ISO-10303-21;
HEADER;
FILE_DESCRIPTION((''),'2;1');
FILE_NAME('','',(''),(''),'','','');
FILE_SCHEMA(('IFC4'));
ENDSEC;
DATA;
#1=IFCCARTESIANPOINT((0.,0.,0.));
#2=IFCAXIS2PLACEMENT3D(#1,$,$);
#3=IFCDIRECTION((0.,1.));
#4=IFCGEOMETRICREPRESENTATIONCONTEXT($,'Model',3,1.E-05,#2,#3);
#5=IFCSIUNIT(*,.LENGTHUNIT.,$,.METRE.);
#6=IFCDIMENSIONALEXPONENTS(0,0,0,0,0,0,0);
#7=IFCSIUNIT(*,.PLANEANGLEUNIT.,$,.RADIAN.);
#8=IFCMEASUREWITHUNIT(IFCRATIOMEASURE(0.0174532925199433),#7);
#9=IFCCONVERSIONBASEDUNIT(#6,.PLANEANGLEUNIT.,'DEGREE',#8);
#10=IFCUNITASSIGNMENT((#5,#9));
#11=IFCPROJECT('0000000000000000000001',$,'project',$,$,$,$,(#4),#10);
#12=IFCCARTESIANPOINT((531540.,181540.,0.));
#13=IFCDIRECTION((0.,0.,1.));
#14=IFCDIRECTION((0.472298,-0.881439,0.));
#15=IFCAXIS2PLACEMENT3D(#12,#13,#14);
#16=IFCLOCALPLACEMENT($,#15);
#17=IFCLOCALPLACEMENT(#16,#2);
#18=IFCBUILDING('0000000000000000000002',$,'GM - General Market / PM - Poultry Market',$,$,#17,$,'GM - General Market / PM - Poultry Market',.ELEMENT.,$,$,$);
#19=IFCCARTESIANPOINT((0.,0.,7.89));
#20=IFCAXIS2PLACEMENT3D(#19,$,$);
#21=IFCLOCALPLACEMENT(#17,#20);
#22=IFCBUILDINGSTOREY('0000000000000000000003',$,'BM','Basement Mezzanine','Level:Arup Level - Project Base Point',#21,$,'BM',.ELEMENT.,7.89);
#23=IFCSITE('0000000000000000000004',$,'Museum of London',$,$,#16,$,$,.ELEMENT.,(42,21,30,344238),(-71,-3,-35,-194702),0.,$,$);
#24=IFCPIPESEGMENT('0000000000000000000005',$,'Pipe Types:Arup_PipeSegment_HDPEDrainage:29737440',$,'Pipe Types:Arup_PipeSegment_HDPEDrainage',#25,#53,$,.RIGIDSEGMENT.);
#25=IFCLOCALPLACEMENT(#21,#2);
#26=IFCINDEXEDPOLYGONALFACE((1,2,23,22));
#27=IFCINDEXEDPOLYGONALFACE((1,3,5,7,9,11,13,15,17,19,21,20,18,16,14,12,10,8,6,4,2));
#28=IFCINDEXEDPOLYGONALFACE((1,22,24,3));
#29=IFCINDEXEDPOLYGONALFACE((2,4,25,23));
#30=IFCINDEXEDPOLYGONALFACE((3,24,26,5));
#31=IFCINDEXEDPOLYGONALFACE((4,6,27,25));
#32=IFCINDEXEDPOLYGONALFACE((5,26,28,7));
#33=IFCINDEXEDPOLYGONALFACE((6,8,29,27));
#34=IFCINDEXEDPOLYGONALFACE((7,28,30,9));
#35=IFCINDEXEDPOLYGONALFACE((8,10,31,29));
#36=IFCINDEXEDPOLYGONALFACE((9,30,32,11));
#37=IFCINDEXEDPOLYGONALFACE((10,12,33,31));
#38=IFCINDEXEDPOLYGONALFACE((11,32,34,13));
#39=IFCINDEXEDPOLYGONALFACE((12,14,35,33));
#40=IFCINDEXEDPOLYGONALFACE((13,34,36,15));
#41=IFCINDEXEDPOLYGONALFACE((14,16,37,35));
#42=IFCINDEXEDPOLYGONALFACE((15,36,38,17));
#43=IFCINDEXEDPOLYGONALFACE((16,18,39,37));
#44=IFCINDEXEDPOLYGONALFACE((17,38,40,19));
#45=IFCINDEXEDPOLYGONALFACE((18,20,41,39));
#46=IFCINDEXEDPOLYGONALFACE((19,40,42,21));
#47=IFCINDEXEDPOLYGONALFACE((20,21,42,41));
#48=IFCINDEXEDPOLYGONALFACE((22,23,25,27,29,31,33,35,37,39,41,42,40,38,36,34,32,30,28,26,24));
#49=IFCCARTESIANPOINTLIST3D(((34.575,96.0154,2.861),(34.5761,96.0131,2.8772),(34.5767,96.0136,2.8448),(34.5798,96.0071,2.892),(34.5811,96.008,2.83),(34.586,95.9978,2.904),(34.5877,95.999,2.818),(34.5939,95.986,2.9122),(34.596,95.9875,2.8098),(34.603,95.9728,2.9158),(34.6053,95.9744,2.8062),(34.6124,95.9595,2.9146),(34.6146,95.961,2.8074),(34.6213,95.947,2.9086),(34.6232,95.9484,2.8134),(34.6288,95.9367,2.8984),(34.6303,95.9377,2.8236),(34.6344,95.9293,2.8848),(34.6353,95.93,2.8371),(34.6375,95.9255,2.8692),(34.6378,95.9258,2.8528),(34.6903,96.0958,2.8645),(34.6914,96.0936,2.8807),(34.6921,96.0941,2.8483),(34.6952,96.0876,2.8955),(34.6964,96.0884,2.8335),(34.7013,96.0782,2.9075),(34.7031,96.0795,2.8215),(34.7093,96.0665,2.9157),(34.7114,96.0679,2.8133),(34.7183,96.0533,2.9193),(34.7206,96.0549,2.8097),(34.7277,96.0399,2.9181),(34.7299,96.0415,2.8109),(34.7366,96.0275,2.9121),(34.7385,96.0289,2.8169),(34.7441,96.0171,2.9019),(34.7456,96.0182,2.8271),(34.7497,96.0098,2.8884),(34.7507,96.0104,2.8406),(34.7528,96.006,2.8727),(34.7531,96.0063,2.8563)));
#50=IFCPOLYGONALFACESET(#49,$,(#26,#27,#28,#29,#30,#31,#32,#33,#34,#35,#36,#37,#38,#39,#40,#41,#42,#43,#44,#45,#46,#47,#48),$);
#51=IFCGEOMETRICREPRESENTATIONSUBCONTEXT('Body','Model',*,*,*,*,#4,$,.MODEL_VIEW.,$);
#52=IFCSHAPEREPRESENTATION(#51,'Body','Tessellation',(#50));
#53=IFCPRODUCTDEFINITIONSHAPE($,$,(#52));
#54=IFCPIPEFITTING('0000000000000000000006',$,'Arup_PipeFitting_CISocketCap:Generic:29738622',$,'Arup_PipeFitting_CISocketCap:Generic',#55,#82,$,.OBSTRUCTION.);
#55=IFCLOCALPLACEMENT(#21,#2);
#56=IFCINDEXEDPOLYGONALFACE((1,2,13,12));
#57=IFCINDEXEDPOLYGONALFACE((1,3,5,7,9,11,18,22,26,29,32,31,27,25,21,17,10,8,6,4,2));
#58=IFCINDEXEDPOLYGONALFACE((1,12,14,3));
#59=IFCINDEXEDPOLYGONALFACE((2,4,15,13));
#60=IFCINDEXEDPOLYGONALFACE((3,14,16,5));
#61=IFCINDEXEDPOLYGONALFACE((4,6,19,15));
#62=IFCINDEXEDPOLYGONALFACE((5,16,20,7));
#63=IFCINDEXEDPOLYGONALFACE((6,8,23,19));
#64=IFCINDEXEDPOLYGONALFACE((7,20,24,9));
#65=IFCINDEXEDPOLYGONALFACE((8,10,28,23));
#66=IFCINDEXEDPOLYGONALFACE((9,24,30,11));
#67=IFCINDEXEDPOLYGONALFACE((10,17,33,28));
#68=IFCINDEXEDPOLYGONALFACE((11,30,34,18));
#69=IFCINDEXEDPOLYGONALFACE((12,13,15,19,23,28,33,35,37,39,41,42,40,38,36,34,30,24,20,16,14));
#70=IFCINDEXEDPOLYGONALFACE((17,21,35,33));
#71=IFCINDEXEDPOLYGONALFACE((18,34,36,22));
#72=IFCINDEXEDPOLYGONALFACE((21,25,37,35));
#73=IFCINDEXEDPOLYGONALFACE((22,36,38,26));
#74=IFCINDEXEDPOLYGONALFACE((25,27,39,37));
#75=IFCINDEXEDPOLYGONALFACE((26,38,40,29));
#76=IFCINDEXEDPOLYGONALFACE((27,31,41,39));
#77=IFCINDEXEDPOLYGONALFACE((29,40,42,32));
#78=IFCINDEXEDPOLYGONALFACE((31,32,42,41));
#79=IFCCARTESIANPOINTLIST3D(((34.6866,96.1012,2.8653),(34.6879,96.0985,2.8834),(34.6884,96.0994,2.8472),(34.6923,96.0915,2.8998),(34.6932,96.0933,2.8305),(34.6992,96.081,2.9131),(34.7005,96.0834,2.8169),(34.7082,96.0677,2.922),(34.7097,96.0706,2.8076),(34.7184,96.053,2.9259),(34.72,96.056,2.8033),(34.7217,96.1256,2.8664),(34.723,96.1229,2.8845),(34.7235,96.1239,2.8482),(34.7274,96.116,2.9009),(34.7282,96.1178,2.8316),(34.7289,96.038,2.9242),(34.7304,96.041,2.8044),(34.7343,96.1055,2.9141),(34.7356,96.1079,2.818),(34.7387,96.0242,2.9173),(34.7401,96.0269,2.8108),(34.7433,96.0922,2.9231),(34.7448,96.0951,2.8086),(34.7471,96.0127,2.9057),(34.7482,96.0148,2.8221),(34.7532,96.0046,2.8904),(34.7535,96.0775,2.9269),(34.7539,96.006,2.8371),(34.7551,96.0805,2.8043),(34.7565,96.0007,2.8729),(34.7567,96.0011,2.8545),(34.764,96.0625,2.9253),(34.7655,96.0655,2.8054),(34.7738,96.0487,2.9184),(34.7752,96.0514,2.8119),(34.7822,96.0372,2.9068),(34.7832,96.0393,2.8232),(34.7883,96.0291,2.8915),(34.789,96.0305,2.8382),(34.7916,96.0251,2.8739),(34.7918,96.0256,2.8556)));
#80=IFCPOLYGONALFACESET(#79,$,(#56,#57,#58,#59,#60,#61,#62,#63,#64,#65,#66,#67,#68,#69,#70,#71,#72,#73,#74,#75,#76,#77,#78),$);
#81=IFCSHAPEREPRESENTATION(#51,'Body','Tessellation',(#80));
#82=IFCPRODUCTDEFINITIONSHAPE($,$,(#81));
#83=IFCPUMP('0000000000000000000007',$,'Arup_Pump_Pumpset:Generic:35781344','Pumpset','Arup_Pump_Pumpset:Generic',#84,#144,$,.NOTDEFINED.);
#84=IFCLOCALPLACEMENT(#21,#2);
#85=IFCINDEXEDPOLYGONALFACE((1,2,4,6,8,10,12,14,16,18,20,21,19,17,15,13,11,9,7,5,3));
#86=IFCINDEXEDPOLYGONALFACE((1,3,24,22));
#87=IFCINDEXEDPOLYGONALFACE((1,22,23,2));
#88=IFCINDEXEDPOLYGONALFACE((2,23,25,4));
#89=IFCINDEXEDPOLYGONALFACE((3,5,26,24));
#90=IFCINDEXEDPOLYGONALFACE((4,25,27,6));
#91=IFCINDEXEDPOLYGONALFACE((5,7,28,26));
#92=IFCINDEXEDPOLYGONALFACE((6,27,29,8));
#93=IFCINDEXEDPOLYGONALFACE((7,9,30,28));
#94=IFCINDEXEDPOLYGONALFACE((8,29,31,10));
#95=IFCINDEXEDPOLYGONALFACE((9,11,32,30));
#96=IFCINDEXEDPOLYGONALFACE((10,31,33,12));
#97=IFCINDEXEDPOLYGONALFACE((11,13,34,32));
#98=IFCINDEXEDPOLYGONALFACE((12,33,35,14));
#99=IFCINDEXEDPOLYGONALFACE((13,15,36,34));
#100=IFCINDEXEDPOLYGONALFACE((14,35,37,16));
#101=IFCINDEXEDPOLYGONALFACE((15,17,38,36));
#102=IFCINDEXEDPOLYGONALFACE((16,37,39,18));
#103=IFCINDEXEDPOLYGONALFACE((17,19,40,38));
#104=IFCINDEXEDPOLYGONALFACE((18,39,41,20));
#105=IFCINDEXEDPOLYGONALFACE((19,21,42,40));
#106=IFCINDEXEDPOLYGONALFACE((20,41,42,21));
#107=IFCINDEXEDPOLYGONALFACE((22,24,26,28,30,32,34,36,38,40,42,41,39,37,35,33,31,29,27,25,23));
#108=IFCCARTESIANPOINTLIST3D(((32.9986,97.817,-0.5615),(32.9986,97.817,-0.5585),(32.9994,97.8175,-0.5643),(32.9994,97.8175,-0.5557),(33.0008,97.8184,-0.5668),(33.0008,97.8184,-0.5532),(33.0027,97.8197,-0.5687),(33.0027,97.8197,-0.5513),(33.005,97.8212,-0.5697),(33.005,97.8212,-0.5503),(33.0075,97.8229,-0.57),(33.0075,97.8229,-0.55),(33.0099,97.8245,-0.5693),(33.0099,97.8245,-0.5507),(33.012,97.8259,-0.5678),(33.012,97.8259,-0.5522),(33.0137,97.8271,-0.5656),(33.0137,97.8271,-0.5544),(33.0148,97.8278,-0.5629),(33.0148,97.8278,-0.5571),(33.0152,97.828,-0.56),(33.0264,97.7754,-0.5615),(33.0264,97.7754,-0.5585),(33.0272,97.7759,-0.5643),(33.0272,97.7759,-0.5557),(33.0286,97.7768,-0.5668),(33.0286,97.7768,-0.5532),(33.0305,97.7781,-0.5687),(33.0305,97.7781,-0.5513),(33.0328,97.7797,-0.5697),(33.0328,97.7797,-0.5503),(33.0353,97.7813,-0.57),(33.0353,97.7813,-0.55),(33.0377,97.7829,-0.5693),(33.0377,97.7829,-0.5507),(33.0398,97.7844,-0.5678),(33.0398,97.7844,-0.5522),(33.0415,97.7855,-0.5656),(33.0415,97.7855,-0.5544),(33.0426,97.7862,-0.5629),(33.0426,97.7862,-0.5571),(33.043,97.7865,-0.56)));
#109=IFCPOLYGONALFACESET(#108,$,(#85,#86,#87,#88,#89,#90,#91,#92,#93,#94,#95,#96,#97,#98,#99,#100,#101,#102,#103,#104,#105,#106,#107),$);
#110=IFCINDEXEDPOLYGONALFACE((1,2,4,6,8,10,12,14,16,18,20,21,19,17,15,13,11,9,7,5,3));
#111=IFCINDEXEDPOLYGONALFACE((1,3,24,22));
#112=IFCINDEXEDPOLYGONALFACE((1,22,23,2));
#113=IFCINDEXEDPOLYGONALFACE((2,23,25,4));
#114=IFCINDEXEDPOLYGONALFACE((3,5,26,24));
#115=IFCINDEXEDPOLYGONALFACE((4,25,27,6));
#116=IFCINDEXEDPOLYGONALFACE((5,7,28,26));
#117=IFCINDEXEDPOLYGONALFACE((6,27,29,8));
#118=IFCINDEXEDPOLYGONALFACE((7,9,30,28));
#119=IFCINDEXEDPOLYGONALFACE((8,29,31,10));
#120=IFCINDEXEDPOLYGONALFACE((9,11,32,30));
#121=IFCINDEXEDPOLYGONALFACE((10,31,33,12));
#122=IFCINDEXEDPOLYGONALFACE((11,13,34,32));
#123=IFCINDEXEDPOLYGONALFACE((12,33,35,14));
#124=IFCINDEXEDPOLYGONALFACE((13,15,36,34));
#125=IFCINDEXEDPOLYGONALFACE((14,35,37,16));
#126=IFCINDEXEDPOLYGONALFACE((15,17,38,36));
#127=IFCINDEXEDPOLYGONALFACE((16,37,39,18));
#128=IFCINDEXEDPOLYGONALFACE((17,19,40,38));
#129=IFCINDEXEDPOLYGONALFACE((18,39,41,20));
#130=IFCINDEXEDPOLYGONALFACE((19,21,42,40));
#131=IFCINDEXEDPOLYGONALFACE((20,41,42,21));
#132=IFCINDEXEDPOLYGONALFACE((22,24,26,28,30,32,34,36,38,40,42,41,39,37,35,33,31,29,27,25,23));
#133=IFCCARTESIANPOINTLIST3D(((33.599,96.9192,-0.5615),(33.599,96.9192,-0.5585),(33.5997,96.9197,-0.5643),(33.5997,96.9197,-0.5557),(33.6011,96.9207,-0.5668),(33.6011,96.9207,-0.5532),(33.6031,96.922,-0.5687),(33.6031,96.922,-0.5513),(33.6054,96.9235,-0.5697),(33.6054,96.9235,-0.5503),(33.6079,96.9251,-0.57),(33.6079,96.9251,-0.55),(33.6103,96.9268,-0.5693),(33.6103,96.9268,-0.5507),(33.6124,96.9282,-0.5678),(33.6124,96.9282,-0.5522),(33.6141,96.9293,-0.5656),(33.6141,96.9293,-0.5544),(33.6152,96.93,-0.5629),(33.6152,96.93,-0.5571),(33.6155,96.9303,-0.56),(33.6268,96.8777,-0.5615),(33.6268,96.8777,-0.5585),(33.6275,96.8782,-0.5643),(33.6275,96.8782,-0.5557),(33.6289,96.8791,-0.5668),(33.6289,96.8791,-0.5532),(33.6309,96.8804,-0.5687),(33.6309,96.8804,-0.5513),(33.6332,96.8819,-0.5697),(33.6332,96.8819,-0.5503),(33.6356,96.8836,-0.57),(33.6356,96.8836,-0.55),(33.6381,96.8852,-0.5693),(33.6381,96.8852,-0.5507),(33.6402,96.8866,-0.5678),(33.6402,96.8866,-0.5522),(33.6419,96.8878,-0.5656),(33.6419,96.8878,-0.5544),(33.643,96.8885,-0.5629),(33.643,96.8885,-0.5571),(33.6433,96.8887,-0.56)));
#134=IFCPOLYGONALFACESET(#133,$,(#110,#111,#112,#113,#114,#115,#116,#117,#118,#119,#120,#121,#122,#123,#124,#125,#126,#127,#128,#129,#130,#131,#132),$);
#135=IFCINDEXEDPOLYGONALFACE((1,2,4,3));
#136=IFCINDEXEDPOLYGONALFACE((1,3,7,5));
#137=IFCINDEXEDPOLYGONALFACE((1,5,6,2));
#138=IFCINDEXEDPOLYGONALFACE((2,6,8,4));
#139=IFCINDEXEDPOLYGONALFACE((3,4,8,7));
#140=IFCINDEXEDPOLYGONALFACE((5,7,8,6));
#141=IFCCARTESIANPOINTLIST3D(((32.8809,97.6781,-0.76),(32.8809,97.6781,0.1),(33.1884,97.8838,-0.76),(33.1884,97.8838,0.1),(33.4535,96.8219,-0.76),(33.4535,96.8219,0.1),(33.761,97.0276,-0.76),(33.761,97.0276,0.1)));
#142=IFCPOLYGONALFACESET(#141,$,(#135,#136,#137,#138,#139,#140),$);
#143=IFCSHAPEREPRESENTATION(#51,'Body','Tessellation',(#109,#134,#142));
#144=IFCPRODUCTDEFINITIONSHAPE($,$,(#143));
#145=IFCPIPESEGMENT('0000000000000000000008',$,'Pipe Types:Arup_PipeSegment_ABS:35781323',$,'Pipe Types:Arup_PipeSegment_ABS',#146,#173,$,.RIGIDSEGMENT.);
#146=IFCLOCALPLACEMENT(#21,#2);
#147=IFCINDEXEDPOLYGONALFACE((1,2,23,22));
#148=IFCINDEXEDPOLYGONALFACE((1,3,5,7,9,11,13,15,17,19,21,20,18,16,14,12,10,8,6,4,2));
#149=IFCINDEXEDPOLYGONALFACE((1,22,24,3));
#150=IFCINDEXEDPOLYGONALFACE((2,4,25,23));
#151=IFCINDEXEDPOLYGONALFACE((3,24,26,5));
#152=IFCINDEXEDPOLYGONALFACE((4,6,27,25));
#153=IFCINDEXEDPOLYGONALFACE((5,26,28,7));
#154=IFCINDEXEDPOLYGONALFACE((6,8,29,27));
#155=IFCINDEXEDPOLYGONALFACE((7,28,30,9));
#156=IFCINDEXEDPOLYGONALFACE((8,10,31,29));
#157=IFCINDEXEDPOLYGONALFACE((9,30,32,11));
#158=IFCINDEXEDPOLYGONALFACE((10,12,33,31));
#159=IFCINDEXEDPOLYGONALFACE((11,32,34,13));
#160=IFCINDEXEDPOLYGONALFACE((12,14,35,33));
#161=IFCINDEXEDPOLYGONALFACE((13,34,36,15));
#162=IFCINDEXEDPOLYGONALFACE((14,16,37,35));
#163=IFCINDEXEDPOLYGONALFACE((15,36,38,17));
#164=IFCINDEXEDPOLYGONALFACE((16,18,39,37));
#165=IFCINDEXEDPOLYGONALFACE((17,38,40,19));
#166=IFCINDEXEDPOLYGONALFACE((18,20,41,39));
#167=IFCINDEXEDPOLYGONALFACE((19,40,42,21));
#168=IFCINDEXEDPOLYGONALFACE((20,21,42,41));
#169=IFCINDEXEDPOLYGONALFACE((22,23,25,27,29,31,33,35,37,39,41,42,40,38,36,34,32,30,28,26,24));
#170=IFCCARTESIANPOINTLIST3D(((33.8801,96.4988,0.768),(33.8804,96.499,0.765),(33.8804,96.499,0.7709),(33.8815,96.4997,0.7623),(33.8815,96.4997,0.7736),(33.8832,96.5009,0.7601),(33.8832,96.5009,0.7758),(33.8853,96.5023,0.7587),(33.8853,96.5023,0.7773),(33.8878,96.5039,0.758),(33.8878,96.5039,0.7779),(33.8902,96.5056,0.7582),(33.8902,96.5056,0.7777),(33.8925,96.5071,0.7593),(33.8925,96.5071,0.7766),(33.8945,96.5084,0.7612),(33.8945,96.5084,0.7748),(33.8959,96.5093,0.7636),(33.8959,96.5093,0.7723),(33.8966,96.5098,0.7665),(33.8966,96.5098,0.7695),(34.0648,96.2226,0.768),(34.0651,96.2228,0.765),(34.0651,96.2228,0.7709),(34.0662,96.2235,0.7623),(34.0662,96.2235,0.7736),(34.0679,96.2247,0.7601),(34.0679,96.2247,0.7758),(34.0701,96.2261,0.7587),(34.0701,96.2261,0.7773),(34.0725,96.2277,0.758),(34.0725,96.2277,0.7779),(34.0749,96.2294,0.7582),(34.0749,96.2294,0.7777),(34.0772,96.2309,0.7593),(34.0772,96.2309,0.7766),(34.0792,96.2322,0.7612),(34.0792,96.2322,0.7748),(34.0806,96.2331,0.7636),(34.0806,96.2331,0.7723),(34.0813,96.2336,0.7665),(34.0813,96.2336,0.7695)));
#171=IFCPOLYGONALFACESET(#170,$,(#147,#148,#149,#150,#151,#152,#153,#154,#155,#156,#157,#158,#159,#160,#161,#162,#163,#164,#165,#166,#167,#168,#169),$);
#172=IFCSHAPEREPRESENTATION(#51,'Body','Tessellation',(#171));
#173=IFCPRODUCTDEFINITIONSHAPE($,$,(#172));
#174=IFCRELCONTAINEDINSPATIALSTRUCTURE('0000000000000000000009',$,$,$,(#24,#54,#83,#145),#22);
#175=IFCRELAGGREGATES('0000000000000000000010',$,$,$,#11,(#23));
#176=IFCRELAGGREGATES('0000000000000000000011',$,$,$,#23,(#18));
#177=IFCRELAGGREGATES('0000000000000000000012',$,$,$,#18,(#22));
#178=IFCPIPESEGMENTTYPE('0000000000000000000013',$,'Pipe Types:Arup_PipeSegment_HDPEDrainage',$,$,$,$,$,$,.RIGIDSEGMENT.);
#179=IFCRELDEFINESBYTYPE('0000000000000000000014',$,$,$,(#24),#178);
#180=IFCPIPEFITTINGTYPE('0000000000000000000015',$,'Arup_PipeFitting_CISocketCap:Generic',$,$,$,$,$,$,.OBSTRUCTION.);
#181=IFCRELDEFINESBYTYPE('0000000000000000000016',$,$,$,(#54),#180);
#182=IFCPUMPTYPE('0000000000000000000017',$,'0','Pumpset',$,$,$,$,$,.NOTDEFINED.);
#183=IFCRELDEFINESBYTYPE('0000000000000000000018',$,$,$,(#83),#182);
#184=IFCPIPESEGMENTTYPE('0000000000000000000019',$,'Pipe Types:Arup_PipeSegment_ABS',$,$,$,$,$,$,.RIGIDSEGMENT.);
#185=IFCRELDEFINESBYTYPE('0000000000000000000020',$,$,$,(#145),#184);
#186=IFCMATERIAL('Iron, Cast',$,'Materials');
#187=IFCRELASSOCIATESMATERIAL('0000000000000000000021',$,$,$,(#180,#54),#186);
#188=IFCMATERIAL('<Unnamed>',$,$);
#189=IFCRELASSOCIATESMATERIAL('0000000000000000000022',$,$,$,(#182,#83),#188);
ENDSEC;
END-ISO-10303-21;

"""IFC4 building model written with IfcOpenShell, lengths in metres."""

from ifc_helpers import new_model, entity, si_unit, converted_unit, direction, frame, frame_2d, origin, origin_2d_with_axis, place, context, subcontext, project, spatial, rectangle, circle, extrude, source, transform, mapped, material, type_object, type_shapes, element, save


model = new_model("IFC4")

# Units and contexts
model_context = context("Model", 3, precision=1e-05, world=origin(), true_north=direction((0.0, 1.0)))
body_context = subcontext(model_context, "Body", "Model", "MODEL_VIEW")
ifc_project = project(units=[si_unit("LENGTHUNIT", "METRE"), converted_unit("PLANEANGLEUNIT", "DEGREE", entity("IfcRatioMeasure", 0.0174532925199433), si_unit("PLANEANGLEUNIT", "RADIAN"), dimensions=[0, 0, 0, 0, 0, 0, 0])], contexts=[model_context])

# Site, building, storey
site_placement = place(None, frame((531540.0, 181540.0, 0.0), z_axis=(0.0, 0.0, 1.0), x_axis=(0.472298, -0.881439, 0.0)))
site = spatial("IfcSite", under=ifc_project, at=site_placement, Name="Museum of London", CompositionType="ELEMENT", RefLatitude=(42, 21, 30, 344238), RefLongitude=(-71, -3, -35, -194702), RefElevation=0.0)
building_placement = place(site_placement, origin())
building = spatial("IfcBuilding", under=site, at=building_placement, Name="GM - General Market / PM - Poultry Market", LongName="GM - General Market / PM - Poultry Market", CompositionType="ELEMENT")
storey_placement = place(building_placement, frame((0.0, 0.0, 7.89)))
storey = spatial("IfcBuildingStorey", under=building, at=storey_placement, Name="BM", Description="Basement Mezzanine", ObjectType="Level:Arup Level - Project Base Point", LongName="BM", CompositionType="ELEMENT", Elevation=7.89)

# Pipe segment
pipe_segment_type_1 = type_object("IfcPipeSegmentType", Name="Pipe Types:Arup_PipeSegment_HDPEDrainage", PredefinedType="RIGIDSEGMENT")
pipe_segment_1_placement = place(storey_placement, frame((34.5734, 95.9236, 2.8044)))
element("IfcPipeSegment", 1, at=pipe_segment_1_placement, inside=storey, type_object=pipe_segment_type_1, Name="Pipe Types:Arup_PipeSegment_HDPEDrainage:29737440", ObjectType="Pipe Types:Arup_PipeSegment_HDPEDrainage", PredefinedType="RIGIDSEGMENT", context=body_context, shape_type="SweptSolid", body=[
    extrude(circle(Radius=0.055, at=origin_2d_with_axis()), frame((0.0331, 0.0467, 0.0566), z_axis=(0.819772, 0.572147, 0.024951), x_axis=(-0.572325, 0.820027, 0.0)), (0.0, 0.0, 1.0), 0.1407),
])

# Pipe fitting
ifc_material_1 = material(Name="Iron, Cast", Category="Materials")
pipe_fitting_type = type_object("IfcPipeFittingType", Name="Arup_PipeFitting_CISocketCap:Generic", PredefinedType="OBSTRUCTION", material=ifc_material_1)
shared_shape_1 = source(origin(), body_context, "Body", "SweptSolid", [
    extrude(circle(Radius=0.0615, at=frame_2d((0.0, 0.0), x_axis=(1.0, 0.0))), frame((0.0, 0.0, 0.0), z_axis=(1.0, 0.0, 0.0), x_axis=(0.0, 1.0, 0.0)), (0.0, 0.0, 1.0), 0.0428),
])
type_shapes(pipe_fitting_type, [shared_shape_1])
pipe_fitting_placement = place(storey_placement, frame((34.7218, 96.0507, 2.8645), z_axis=(-0.012892, -0.025121, 0.999601), x_axis=(0.819772, 0.572147, 0.024951)))
element("IfcPipeFitting", 2, at=pipe_fitting_placement, inside=storey, type_object=pipe_fitting_type, material=ifc_material_1, Name="Arup_PipeFitting_CISocketCap:Generic:29738622", ObjectType="Arup_PipeFitting_CISocketCap:Generic", PredefinedType="OBSTRUCTION", context=body_context, shape_type="MappedRepresentation", body=[
    mapped(shared_shape_1, transform((0.0, 0.0, 0.0), scale=1.0)),
])

# Pump
ifc_material_2 = material(Name="<Unnamed>")
pump_type = type_object("IfcPumpType", Name="0", Description="Pumpset", PredefinedType="NOTDEFINED", material=ifc_material_2)
shared_shape_2 = source(origin(), body_context, "Body", "SweptSolid", [
    extrude(circle(Radius=0.01, at=frame_2d((0.0, 0.0), x_axis=(1.0, 0.0))), frame((-0.015, 0.515, 0.2), z_axis=(0.0, 1.0, 0.0), x_axis=(1.0, 0.0, 0.0)), (0.0, 0.0, 1.0), 0.05),
    extrude(circle(Radius=0.01, at=frame_2d((0.0, 0.0), x_axis=(1.0, 0.0))), frame((-0.015, -0.565, 0.2), z_axis=(0.0, 1.0, 0.0), x_axis=(1.0, 0.0, 0.0)), (0.0, 0.0, 1.0), 0.05),
    extrude(rectangle(XDim=1.03, YDim=0.37, at=origin_2d_with_axis()), frame((-0.015, 0.0, 0.0), z_axis=(0.0, 0.0, 1.0), x_axis=(0.0, 1.0, 0.0)), (0.0, 0.0, 1.0), 0.86),
])
type_shapes(pump_type, [shared_shape_2])
pump_placement = place(storey_placement, frame((33.3334, 97.3612, -0.76), z_axis=(0.0, 0.0, 1.0), x_axis=(0.831246, 0.555905, 0.0)))
element("IfcPump", 3, at=pump_placement, inside=storey, type_object=pump_type, material=ifc_material_2, Name="Arup_Pump_Pumpset:Generic:35781344", Description="Pumpset", ObjectType="Arup_Pump_Pumpset:Generic", PredefinedType="NOTDEFINED", context=body_context, shape_type="MappedRepresentation", body=[
    mapped(shared_shape_2, transform((0.0, 0.0, 0.0), scale=1.0)),
])

# Pipe segment
pipe_segment_type_2 = type_object("IfcPipeSegmentType", Name="Pipe Types:Arup_PipeSegment_ABS", PredefinedType="RIGIDSEGMENT")
pipe_segment_2_placement = place(storey_placement, frame((33.8785, 96.221, 0.7564)))
element("IfcPipeSegment", 4, at=pipe_segment_2_placement, inside=storey, type_object=pipe_segment_type_2, Name="Pipe Types:Arup_PipeSegment_ABS:35781323", ObjectType="Pipe Types:Arup_PipeSegment_ABS", PredefinedType="RIGIDSEGMENT", context=body_context, shape_type="SweptSolid", body=[
    extrude(circle(Radius=0.01, at=origin_2d_with_axis()), frame((0.0099, 0.2834, 0.0116), z_axis=(0.555905, -0.831246, 0.0), x_axis=(-0.831246, -0.555905, 0.0)), (0.0, 0.0, 1.0), 0.3323),
])

save(model, "model.ifc")
